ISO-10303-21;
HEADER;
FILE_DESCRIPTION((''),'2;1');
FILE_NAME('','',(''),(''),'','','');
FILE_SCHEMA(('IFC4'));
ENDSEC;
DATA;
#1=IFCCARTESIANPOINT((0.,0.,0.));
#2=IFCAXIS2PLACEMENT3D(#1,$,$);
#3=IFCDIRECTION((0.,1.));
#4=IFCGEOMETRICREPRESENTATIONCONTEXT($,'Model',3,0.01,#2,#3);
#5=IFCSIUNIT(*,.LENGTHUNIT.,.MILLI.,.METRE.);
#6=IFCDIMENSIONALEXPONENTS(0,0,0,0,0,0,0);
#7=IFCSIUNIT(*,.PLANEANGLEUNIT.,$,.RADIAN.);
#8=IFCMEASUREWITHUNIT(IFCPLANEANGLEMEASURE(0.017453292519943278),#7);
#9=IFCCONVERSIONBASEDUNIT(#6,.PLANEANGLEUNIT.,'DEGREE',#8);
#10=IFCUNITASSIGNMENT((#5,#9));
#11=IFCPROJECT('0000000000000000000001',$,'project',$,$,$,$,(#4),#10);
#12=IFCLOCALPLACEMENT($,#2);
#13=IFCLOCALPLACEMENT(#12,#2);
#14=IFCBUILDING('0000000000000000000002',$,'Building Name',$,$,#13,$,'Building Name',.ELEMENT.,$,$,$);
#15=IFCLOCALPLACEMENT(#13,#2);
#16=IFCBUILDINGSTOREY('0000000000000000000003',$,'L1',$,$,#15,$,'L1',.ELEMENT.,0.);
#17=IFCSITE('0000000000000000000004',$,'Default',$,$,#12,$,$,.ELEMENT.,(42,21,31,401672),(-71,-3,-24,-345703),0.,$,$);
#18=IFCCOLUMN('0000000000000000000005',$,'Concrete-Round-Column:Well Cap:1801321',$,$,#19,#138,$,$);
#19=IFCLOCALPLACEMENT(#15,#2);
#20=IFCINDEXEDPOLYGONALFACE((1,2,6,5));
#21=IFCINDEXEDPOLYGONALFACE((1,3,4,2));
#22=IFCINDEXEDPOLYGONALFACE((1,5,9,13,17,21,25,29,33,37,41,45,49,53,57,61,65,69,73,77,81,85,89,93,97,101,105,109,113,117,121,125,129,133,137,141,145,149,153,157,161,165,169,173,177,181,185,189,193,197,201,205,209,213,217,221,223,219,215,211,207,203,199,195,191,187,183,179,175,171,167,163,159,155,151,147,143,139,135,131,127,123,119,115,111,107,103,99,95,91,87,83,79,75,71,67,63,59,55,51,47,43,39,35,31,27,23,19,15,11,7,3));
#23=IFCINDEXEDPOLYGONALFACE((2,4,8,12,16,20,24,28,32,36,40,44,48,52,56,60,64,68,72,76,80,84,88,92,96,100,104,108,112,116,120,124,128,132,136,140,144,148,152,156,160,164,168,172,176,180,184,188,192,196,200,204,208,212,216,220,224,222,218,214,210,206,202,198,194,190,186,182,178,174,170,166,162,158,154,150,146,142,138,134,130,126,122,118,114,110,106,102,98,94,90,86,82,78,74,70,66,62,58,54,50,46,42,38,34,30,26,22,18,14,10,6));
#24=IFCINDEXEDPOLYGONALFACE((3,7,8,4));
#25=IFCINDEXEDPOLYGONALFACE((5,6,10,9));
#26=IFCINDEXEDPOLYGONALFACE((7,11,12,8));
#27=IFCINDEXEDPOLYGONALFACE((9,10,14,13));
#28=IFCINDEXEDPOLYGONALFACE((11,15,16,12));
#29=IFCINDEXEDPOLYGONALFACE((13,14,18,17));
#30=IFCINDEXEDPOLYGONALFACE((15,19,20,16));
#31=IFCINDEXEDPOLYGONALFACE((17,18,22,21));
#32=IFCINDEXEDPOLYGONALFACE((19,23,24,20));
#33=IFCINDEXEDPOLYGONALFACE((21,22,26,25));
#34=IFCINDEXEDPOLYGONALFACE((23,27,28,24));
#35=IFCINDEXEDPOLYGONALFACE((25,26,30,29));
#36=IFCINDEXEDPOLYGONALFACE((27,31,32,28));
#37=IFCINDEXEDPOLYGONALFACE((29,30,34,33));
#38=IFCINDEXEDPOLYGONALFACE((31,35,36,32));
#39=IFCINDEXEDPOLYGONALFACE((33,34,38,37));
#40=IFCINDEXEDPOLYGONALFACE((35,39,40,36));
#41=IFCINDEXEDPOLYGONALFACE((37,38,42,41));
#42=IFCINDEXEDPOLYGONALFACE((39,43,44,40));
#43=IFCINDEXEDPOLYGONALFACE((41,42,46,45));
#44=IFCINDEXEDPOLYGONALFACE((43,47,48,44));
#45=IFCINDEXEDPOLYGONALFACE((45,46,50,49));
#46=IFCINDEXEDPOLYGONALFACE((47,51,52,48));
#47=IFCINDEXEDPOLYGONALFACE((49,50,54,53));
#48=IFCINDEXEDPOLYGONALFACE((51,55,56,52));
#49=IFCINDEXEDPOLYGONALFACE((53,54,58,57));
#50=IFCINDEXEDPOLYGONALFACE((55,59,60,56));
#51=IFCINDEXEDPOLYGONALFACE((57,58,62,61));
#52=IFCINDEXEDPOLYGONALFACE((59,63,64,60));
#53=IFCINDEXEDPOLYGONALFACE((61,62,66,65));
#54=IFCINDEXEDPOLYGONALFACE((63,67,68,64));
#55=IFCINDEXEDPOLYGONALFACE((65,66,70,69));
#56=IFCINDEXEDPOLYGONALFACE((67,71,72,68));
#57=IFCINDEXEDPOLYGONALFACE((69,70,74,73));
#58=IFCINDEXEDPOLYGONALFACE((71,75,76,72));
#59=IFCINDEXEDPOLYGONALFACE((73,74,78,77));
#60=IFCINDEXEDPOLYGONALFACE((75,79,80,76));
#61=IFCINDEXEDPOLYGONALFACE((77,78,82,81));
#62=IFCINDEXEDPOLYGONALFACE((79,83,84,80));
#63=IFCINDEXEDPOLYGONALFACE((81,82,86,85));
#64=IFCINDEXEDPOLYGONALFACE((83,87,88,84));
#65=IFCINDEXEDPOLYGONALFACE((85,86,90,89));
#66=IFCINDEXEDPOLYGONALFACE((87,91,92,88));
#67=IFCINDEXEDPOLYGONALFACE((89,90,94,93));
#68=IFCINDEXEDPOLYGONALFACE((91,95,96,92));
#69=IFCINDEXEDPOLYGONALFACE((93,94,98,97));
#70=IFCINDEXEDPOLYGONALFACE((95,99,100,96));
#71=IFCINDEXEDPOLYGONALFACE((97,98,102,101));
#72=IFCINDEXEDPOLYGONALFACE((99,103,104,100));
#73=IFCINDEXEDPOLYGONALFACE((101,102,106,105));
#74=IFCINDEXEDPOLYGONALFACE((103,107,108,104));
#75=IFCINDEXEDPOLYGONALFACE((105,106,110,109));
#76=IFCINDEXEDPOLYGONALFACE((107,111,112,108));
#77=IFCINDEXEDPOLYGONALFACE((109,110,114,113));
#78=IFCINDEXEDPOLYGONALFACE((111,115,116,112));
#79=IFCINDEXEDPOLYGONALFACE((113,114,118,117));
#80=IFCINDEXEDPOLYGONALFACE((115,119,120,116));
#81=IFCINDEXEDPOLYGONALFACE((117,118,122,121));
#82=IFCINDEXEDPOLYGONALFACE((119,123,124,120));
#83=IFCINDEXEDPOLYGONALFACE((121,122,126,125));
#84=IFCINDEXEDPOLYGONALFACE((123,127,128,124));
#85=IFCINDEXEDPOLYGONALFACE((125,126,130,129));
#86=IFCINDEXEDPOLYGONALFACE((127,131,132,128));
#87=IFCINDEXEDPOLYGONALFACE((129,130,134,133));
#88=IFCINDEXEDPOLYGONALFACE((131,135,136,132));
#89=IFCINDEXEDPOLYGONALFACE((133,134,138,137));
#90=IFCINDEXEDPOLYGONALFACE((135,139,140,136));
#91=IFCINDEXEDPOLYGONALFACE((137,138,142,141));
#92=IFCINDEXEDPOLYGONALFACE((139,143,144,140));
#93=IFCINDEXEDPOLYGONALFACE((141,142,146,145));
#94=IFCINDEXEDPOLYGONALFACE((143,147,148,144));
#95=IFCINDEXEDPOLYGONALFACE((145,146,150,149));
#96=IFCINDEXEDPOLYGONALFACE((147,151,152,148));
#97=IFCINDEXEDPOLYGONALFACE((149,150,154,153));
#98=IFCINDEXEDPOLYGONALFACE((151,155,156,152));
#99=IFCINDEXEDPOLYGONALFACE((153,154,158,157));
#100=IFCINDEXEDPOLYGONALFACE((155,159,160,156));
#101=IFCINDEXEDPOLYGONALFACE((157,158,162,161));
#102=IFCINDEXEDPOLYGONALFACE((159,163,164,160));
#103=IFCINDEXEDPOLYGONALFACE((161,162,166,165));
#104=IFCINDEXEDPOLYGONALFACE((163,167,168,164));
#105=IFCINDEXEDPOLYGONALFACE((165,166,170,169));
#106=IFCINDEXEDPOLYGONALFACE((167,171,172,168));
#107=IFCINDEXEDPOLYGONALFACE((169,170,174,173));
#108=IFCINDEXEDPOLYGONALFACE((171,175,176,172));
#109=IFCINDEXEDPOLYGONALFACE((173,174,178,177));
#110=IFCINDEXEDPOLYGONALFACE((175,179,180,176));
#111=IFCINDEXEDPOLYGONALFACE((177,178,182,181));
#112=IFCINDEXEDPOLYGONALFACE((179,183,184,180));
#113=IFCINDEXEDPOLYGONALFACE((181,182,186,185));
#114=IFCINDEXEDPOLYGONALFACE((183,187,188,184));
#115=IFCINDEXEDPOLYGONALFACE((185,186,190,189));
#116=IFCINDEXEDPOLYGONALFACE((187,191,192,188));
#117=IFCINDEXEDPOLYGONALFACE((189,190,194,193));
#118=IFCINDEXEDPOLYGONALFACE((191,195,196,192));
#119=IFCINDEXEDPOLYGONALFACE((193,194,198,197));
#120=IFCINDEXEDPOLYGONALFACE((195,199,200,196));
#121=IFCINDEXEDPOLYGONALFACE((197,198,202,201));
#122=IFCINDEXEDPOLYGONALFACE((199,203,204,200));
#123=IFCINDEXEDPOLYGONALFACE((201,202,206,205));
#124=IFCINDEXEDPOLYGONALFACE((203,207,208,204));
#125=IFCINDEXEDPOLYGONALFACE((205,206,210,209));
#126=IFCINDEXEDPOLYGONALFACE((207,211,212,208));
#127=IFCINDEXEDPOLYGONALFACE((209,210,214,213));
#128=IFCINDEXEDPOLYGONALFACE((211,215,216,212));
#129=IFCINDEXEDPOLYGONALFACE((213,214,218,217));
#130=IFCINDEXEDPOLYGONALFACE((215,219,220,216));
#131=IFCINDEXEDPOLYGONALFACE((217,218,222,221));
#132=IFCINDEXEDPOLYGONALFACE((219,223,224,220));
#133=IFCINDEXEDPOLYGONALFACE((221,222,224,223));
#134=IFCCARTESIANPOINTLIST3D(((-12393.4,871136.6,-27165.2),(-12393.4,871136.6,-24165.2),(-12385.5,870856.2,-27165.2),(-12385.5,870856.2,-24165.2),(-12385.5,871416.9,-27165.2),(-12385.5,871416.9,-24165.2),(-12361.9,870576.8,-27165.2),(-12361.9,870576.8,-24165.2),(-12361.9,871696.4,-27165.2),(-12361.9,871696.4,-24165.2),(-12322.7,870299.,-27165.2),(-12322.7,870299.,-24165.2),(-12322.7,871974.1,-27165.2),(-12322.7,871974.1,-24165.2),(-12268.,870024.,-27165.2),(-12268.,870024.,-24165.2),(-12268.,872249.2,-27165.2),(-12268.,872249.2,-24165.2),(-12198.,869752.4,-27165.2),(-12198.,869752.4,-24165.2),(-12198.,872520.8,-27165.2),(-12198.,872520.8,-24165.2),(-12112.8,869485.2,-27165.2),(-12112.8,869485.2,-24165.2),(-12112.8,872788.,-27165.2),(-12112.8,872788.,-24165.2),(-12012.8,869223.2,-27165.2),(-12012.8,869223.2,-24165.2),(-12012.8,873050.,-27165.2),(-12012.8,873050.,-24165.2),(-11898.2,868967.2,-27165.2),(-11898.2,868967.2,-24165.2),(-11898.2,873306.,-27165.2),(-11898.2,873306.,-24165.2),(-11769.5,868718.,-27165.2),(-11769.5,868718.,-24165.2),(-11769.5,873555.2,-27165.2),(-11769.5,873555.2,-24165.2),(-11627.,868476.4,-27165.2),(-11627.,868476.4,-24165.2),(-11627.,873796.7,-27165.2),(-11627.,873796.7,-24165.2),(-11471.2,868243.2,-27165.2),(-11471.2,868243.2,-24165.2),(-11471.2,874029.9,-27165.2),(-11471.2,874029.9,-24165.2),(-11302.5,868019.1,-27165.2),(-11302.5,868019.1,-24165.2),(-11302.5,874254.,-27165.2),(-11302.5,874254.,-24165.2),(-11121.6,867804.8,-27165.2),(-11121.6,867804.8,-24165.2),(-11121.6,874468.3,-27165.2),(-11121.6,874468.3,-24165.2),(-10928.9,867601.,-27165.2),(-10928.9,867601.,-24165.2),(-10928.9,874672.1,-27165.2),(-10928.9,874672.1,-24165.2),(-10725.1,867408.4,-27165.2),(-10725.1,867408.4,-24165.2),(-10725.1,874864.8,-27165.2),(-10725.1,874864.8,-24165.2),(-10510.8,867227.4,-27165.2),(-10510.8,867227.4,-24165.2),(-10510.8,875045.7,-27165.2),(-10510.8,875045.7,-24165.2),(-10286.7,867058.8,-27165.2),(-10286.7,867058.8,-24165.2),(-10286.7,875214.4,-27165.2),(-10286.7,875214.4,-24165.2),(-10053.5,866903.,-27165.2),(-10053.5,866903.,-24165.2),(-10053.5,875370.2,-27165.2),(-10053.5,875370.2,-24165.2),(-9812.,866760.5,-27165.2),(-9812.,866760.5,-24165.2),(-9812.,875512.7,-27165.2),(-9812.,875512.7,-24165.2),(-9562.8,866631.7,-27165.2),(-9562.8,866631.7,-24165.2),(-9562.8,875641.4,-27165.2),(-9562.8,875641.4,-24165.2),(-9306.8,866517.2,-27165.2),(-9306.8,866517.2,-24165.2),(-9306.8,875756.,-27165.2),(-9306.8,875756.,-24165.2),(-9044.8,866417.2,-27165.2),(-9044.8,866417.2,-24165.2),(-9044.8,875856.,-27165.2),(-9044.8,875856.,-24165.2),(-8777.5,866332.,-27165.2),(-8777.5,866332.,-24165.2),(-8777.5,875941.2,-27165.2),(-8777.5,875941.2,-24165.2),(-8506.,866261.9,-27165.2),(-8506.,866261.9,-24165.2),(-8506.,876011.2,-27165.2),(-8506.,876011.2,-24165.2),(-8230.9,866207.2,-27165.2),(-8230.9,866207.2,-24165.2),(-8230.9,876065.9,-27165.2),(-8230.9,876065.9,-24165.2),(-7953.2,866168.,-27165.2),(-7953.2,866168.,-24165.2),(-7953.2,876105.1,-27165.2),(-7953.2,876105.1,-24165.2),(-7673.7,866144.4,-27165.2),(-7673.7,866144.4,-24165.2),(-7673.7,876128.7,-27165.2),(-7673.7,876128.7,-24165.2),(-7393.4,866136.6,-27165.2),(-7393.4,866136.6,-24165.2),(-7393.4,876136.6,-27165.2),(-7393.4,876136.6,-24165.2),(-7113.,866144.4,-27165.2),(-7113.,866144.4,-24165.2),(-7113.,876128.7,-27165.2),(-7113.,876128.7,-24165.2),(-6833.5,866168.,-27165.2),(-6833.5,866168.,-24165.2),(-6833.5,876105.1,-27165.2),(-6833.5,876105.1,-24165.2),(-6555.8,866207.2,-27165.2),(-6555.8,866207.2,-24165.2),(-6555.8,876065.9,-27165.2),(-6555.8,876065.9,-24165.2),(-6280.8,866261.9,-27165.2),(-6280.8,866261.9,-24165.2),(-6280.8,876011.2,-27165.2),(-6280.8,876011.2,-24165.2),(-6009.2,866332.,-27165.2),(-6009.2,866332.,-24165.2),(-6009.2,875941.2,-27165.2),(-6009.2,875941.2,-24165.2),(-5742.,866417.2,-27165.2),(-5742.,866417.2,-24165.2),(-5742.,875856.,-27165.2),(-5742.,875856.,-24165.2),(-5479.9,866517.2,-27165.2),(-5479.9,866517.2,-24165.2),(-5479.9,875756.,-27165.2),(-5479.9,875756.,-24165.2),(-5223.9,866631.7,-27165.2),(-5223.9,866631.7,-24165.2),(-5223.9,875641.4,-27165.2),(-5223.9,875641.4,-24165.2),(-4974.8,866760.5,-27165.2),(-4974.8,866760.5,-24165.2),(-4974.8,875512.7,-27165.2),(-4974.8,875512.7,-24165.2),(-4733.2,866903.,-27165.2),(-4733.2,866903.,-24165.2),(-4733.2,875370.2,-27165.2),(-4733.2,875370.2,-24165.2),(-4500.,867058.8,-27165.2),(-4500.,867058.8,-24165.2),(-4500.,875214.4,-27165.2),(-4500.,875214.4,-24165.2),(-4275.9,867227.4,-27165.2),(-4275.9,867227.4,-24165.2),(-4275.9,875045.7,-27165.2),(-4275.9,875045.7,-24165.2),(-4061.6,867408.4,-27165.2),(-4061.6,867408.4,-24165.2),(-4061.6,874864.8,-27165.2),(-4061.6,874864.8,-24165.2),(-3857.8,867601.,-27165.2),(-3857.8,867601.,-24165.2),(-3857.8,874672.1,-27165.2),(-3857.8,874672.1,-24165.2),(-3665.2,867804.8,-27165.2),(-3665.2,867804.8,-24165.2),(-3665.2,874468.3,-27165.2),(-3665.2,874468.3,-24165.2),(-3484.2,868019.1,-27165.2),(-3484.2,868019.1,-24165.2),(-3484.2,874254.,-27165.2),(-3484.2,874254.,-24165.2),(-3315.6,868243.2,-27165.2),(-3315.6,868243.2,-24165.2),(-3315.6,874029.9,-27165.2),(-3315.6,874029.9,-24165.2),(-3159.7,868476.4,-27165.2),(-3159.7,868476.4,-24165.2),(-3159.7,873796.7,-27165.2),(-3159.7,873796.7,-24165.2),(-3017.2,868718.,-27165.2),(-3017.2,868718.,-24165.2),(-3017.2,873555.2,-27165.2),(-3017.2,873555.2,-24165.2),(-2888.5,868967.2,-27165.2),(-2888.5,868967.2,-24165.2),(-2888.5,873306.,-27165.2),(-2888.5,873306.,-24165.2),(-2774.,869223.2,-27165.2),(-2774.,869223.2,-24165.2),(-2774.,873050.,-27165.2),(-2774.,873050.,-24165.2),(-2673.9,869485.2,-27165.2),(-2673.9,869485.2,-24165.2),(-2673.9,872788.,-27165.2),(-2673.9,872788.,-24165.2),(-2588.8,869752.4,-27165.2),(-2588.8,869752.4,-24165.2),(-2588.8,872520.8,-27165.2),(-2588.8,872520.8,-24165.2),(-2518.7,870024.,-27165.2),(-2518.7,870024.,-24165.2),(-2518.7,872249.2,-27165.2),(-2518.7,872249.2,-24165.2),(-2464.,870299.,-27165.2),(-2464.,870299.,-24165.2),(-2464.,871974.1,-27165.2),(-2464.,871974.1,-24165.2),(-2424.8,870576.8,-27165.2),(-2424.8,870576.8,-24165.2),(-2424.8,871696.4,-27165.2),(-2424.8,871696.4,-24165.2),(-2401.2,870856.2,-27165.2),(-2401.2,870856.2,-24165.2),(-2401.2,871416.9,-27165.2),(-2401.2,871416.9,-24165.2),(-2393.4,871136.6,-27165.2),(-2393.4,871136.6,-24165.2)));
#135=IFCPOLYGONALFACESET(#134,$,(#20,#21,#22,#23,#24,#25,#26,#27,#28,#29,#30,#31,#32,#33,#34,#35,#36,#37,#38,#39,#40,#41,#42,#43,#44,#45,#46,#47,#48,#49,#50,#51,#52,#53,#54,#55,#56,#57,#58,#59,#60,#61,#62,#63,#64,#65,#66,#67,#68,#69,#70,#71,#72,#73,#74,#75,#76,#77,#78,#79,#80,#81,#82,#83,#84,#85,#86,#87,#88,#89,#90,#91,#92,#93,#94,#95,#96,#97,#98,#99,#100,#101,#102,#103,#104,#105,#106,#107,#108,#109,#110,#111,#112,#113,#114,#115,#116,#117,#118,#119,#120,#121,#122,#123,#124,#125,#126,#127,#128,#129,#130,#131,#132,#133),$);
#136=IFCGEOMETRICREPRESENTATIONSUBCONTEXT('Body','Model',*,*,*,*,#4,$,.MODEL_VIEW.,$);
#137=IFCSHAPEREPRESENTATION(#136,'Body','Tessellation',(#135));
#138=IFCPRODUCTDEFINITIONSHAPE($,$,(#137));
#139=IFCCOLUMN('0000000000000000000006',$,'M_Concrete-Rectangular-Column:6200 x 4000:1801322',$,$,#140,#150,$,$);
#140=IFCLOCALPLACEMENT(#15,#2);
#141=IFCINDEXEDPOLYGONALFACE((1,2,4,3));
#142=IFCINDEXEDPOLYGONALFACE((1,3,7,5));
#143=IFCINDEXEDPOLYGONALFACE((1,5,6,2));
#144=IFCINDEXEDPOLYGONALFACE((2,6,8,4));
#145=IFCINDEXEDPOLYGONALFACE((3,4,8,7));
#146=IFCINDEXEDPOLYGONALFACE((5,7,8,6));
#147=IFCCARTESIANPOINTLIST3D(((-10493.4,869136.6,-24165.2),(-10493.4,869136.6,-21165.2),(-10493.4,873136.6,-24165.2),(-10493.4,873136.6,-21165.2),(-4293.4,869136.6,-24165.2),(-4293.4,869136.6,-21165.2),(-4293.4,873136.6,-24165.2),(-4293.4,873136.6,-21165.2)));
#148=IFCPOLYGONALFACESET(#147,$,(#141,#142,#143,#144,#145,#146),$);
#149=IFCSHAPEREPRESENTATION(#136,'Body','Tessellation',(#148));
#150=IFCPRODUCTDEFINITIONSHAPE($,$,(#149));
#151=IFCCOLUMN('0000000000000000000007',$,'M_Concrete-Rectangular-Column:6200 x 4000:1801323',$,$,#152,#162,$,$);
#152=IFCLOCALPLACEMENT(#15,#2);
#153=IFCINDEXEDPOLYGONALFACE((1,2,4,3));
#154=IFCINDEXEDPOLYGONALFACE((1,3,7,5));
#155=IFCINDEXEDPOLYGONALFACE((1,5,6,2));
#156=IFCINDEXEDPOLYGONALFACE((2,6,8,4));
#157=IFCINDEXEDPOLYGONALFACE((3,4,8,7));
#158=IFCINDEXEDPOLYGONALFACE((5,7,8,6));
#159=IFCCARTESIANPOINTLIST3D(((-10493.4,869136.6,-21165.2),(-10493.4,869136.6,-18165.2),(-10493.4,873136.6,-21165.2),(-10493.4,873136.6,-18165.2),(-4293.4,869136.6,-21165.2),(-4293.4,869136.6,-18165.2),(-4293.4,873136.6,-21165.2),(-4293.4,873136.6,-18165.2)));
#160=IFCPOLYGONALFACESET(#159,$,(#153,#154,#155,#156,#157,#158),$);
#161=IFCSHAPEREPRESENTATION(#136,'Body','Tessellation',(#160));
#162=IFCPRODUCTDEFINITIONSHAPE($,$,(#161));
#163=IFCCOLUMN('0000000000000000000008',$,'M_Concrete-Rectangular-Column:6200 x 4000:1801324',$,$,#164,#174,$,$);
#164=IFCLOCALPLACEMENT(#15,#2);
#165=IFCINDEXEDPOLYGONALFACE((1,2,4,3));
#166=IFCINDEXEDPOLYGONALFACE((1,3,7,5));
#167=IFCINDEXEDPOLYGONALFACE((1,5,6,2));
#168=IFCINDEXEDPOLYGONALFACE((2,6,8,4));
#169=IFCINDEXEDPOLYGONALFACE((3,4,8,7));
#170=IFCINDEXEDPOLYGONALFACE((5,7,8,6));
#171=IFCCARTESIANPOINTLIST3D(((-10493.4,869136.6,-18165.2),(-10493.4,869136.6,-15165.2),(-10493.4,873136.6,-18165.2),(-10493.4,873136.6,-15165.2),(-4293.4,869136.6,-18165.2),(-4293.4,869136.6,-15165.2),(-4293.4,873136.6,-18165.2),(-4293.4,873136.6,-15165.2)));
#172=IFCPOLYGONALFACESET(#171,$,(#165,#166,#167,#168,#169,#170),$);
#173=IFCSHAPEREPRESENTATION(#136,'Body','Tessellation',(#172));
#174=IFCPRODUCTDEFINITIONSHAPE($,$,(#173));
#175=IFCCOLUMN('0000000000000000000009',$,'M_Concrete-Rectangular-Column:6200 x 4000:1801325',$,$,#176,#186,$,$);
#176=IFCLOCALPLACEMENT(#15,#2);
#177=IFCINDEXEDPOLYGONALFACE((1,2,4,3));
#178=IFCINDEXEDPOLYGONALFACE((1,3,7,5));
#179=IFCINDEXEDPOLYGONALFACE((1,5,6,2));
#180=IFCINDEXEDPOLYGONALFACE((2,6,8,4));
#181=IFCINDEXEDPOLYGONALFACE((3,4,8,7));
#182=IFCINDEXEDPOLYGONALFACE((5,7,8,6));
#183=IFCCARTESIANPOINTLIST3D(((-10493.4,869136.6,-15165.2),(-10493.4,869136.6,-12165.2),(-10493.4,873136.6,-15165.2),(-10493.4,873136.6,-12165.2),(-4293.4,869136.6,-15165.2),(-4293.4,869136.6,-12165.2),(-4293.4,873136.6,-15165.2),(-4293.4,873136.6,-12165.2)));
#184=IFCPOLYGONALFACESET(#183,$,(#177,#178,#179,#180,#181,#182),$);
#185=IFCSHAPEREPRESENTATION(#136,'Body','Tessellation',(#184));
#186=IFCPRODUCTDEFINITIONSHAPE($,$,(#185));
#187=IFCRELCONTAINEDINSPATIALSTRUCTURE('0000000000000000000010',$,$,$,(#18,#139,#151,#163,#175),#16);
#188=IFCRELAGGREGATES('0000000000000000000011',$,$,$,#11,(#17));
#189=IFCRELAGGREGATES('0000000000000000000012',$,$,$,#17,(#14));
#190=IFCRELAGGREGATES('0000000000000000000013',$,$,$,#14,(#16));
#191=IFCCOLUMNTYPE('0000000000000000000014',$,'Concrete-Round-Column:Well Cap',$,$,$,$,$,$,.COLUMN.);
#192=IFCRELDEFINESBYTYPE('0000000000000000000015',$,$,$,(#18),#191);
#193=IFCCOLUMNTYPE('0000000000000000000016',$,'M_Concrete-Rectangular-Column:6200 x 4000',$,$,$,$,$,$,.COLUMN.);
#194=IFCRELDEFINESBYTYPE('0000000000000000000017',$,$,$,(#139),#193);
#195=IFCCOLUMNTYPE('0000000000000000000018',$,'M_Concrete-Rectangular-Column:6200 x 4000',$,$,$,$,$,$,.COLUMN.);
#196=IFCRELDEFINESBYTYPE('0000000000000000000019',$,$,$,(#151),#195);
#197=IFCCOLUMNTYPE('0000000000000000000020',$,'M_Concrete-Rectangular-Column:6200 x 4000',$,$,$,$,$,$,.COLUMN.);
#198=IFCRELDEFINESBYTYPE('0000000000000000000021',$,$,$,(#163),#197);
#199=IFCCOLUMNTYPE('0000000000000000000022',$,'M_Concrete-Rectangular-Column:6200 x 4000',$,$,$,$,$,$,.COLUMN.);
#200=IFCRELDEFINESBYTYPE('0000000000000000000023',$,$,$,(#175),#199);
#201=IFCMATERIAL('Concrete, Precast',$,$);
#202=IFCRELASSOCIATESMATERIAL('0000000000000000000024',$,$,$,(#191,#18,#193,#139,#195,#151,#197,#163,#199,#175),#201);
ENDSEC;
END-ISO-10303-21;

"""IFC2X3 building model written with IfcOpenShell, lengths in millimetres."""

from ifc_helpers import new_model, entity, si_unit, converted_unit, direction, frame, frame_2d, origin, place, context, subcontext, project, spatial, rectangle, circle, extrude, source, transform, mapped, material, type_object, type_shapes, element, save


model = new_model("IFC2X3")

# Units and contexts
model_context = context("Model", 3, precision=0.01, world=origin(), true_north=direction((0.0, 1.0)))
body_context = subcontext(model_context, "Body", "Model", "MODEL_VIEW")
ifc_project = project(units=[si_unit("LENGTHUNIT", "METRE", prefix="MILLI"), converted_unit("PLANEANGLEUNIT", "DEGREE", entity("IfcPlaneAngleMeasure", 0.017453292519943278), si_unit("PLANEANGLEUNIT", "RADIAN"), dimensions=[0, 0, 0, 0, 0, 0, 0])], contexts=[model_context])

# Site, building, storey
site_placement = place(None, origin())
site = spatial("IfcSite", under=ifc_project, at=site_placement, Name="Default", CompositionType="ELEMENT", RefLatitude=(42, 21, 31, 401672), RefLongitude=(-71, -3, -24, -345703), RefElevation=0.0)
building_placement = place(site_placement, origin())
building = spatial("IfcBuilding", under=site, at=building_placement, Name="Building Name", LongName="Building Name", CompositionType="ELEMENT")
storey_placement = place(building_placement, origin())
storey = spatial("IfcBuildingStorey", under=building, at=storey_placement, Name="L1", LongName="L1", CompositionType="ELEMENT", Elevation=0.0)

# Columns
ifc_material_1 = material(Name="Concrete, Precast")
column_type_1 = type_object("IfcColumnType", Name="Concrete-Round-Column:Well Cap", PredefinedType="COLUMN", material=ifc_material_1)
shared_shape_1 = source(origin(), body_context, "Body", "SweptSolid", [
    extrude(circle(Radius=5000.0, at=frame_2d((0.0, 0.0), x_axis=(1.0, 0.0))), frame((-7393.4, 871136.6, -27165.2)), (0.0, 0.0, 1.0), 3000.0),
])
type_shapes(column_type_1, [shared_shape_1])
column_1_placement = place(storey_placement, origin())
element("IfcColumn", 1, at=column_1_placement, inside=storey, type_object=column_type_1, material=ifc_material_1, Name="Concrete-Round-Column:Well Cap:1801321", context=body_context, shape_type="MappedRepresentation", body=[
    mapped(shared_shape_1, transform((0.0, 0.0, 0.0), scale=1.0)),
])
column_type_2 = type_object("IfcColumnType", Name="M_Concrete-Rectangular-Column:6200 x 4000", PredefinedType="COLUMN", material=ifc_material_1)
shared_shape_2 = source(origin(), body_context, "Body", "SweptSolid", [
    extrude(rectangle(XDim=4000.0, YDim=6200.0, at=frame_2d((0.0, 0.0), x_axis=(1.0, 0.0))), frame((-7393.4, 871136.6, -24165.2), z_axis=(0.0, 0.0, 1.0), x_axis=(0.0, -1.0, 0.0)), (0.0, 0.0, 1.0), 3000.0),
])
type_shapes(column_type_2, [shared_shape_2])
column_2_placement = place(storey_placement, origin())
element("IfcColumn", 2, at=column_2_placement, inside=storey, type_object=column_type_2, material=ifc_material_1, Name="M_Concrete-Rectangular-Column:6200 x 4000:1801322", context=body_context, shape_type="MappedRepresentation", body=[
    mapped(shared_shape_2, transform((0.0, 0.0, 0.0), scale=1.0)),
])
column_type_3 = type_object("IfcColumnType", Name="M_Concrete-Rectangular-Column:6200 x 4000", PredefinedType="COLUMN", material=ifc_material_1)
shared_shape_3 = source(origin(), body_context, "Body", "SweptSolid", [
    extrude(rectangle(XDim=4000.0, YDim=6200.0, at=frame_2d((0.0, 0.0), x_axis=(1.0, 0.0))), frame((-7393.4, 871136.6, -21165.2), z_axis=(0.0, 0.0, 1.0), x_axis=(0.0, -1.0, 0.0)), (0.0, 0.0, 1.0), 3000.0),
])
type_shapes(column_type_3, [shared_shape_3])
column_3_placement = place(storey_placement, origin())
element("IfcColumn", 3, at=column_3_placement, inside=storey, type_object=column_type_3, material=ifc_material_1, Name="M_Concrete-Rectangular-Column:6200 x 4000:1801323", context=body_context, shape_type="MappedRepresentation", body=[
    mapped(shared_shape_3, transform((0.0, 0.0, 0.0), scale=1.0)),
])
column_type_4 = type_object("IfcColumnType", Name="M_Concrete-Rectangular-Column:6200 x 4000", PredefinedType="COLUMN", material=ifc_material_1)
shared_shape_4 = source(origin(), body_context, "Body", "SweptSolid", [
    extrude(rectangle(XDim=4000.0, YDim=6200.0, at=frame_2d((0.0, 0.0), x_axis=(1.0, 0.0))), frame((-7393.4, 871136.6, -18165.2), z_axis=(0.0, 0.0, 1.0), x_axis=(0.0, -1.0, 0.0)), (0.0, 0.0, 1.0), 3000.0),
])
type_shapes(column_type_4, [shared_shape_4])
column_4_placement = place(storey_placement, origin())
element("IfcColumn", 4, at=column_4_placement, inside=storey, type_object=column_type_4, material=ifc_material_1, Name="M_Concrete-Rectangular-Column:6200 x 4000:1801324", context=body_context, shape_type="MappedRepresentation", body=[
    mapped(shared_shape_4, transform((0.0, 0.0, 0.0), scale=1.0)),
])
column_type_5 = type_object("IfcColumnType", Name="M_Concrete-Rectangular-Column:6200 x 4000", PredefinedType="COLUMN", material=ifc_material_1)
shared_shape_5 = source(origin(), body_context, "Body", "SweptSolid", [
    extrude(rectangle(XDim=4000.0, YDim=6200.0, at=frame_2d((0.0, 0.0), x_axis=(1.0, 0.0))), frame((-7393.4, 871136.6, -15165.2), z_axis=(0.0, 0.0, 1.0), x_axis=(0.0, -1.0, 0.0)), (0.0, 0.0, 1.0), 3000.0),
])
type_shapes(column_type_5, [shared_shape_5])
column_5_placement = place(storey_placement, origin())
element("IfcColumn", 5, at=column_5_placement, inside=storey, type_object=column_type_5, material=ifc_material_1, Name="M_Concrete-Rectangular-Column:6200 x 4000:1801325", context=body_context, shape_type="MappedRepresentation", body=[
    mapped(shared_shape_5, transform((0.0, 0.0, 0.0), scale=1.0)),
])

save(model, "model.ifc")
